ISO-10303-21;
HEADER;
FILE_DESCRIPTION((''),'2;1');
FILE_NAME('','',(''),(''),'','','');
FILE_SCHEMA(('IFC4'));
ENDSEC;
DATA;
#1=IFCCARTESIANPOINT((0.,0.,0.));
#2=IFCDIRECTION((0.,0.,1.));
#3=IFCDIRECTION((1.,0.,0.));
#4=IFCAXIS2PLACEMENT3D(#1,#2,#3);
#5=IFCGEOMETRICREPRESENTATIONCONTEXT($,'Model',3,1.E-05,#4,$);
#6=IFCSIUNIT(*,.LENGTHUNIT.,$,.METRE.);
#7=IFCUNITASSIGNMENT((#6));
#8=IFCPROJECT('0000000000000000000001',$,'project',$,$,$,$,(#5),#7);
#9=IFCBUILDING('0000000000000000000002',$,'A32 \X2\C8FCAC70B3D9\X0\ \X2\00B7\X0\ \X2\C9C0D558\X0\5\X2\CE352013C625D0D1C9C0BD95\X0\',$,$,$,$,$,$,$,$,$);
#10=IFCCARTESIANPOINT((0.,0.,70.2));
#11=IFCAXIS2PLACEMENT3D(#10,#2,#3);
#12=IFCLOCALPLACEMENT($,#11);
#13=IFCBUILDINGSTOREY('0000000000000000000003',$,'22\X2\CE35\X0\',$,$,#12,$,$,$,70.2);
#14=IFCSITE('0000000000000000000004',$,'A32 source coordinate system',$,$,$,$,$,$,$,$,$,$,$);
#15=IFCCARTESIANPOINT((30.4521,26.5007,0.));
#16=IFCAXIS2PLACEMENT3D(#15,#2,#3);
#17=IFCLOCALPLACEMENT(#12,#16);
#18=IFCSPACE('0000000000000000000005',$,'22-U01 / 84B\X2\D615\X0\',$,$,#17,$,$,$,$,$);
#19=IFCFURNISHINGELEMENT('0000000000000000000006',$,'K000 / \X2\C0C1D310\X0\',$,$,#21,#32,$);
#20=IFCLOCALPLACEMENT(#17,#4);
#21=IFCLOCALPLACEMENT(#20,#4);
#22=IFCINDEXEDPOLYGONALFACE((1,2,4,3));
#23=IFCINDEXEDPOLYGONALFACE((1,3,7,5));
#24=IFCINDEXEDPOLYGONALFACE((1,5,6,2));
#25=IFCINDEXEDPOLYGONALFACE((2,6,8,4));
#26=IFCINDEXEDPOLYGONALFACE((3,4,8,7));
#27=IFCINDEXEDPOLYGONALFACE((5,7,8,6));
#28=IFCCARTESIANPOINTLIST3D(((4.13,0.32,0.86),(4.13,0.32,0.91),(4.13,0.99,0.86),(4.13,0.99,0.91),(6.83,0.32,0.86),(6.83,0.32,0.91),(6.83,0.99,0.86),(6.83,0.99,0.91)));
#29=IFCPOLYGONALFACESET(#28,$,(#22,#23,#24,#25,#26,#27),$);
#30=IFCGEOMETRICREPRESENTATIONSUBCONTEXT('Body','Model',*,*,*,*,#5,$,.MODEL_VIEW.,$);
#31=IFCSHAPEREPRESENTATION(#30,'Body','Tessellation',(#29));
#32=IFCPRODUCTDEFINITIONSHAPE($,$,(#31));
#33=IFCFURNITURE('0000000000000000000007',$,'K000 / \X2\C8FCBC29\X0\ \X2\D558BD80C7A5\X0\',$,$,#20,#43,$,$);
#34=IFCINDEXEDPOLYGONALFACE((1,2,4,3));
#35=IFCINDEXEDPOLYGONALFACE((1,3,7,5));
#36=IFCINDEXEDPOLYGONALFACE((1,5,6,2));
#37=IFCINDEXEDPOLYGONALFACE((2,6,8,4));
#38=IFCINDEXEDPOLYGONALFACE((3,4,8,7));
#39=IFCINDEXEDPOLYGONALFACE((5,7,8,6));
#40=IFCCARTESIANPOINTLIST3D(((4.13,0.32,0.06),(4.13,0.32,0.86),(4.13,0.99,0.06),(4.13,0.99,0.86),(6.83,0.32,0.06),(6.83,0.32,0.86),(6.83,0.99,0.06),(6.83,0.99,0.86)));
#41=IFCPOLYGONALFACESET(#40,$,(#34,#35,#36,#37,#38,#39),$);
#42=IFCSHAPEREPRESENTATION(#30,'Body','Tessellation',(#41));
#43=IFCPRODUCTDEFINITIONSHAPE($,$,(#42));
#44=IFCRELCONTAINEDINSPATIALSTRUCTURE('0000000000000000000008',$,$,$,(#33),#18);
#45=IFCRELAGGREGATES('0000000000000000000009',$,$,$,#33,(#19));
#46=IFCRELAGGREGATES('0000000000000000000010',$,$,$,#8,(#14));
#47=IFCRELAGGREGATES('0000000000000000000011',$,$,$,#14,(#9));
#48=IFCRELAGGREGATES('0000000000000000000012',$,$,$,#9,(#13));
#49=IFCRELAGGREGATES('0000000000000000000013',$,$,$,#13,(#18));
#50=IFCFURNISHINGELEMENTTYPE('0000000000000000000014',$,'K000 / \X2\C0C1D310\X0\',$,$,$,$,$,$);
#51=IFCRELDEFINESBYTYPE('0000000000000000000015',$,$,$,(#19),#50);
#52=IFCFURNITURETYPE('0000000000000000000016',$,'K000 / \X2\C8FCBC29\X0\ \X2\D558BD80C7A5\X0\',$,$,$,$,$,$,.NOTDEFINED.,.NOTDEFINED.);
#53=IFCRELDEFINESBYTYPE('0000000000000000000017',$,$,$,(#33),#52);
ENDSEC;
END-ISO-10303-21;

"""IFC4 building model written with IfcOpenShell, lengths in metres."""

from ifc_helpers import new_model, si_unit, frame, origin, origin_with_axes, place, context, subcontext, project, spatial, polyline, outline, extrude, source, transform, mapped, type_object, type_shapes, element, aggregate, save


model = new_model("IFC4")

# Units and contexts
model_context = context("Model", 3, precision=1e-05, world=origin_with_axes())
body_context = subcontext(model_context, "Body", "Model", "MODEL_VIEW")
ifc_project = project(units=[si_unit("LENGTHUNIT", "METRE")], contexts=[model_context])

# Site, building, storey, space
site = spatial("IfcSite", under=ifc_project, Name="A32 source coordinate system")
building = spatial("IfcBuilding", under=site, Name="A32 주거동 · 지하5층–옥탑지붕")
storey_placement = place(None, frame((0.0, 0.0, 70.2), z_axis=(0.0, 0.0, 1.0), x_axis=(1.0, 0.0, 0.0)))
storey = spatial("IfcBuildingStorey", under=building, at=storey_placement, Name="22층", Elevation=70.2)
space_placement = place(storey_placement, frame((30.4521, 26.5007, 0.0), z_axis=(0.0, 0.0, 1.0), x_axis=(1.0, 0.0, 0.0)))
space = spatial("IfcSpace", under=storey, at=space_placement, Name="22-U01 / 84B형")

# Furnishing element
furnishing_element_type = type_object("IfcFurnishingElementType", Name="K000 / 상판")
shared_shape_1 = source(origin(), body_context, "Body", "SweptSolid", [
    extrude(outline(polyline([(4.13, 0.32), (4.13, 0.99), (6.83, 0.99), (6.83, 0.32), (4.13, 0.32)])), frame((0.0, 0.0, 0.86)), (0.0, 0.0, 1.0), 0.05),
])
type_shapes(furnishing_element_type, [shared_shape_1])
furniture_placement = place(space_placement, origin_with_axes())
furnishing_placement = place(furniture_placement, origin_with_axes())
furnishing = element("IfcFurnishingElement", 1, at=furnishing_placement, type_object=furnishing_element_type, Name="K000 / 상판", context=body_context, shape_type="MappedRepresentation", body=[
    mapped(shared_shape_1, transform((0.0, 0.0, 0.0), scale=1.0)),
])

# Furniture
furniture_type = type_object("IfcFurnitureType", Name="K000 / 주방 하부장", AssemblyPlace="NOTDEFINED", PredefinedType="NOTDEFINED")
shared_shape_2 = source(origin(), body_context, "Body", "SweptSolid", [
    extrude(outline(polyline([(6.83, 0.32), (4.13, 0.32), (4.13, 0.99), (6.83, 0.99), (6.83, 0.32)])), frame((0.0, 0.0, 0.06)), (0.0, 0.0, 1.0), 0.8),
])
type_shapes(furniture_type, [shared_shape_2])
furniture = element("IfcFurniture", 2, at=furniture_placement, inside=space, type_object=furniture_type, Name="K000 / 주방 하부장", context=body_context, shape_type="MappedRepresentation", body=[
    mapped(shared_shape_2, transform((0.0, 0.0, 0.0), scale=1.0)),
])
aggregate(furniture, [furnishing])

save(model, "model.ifc")
